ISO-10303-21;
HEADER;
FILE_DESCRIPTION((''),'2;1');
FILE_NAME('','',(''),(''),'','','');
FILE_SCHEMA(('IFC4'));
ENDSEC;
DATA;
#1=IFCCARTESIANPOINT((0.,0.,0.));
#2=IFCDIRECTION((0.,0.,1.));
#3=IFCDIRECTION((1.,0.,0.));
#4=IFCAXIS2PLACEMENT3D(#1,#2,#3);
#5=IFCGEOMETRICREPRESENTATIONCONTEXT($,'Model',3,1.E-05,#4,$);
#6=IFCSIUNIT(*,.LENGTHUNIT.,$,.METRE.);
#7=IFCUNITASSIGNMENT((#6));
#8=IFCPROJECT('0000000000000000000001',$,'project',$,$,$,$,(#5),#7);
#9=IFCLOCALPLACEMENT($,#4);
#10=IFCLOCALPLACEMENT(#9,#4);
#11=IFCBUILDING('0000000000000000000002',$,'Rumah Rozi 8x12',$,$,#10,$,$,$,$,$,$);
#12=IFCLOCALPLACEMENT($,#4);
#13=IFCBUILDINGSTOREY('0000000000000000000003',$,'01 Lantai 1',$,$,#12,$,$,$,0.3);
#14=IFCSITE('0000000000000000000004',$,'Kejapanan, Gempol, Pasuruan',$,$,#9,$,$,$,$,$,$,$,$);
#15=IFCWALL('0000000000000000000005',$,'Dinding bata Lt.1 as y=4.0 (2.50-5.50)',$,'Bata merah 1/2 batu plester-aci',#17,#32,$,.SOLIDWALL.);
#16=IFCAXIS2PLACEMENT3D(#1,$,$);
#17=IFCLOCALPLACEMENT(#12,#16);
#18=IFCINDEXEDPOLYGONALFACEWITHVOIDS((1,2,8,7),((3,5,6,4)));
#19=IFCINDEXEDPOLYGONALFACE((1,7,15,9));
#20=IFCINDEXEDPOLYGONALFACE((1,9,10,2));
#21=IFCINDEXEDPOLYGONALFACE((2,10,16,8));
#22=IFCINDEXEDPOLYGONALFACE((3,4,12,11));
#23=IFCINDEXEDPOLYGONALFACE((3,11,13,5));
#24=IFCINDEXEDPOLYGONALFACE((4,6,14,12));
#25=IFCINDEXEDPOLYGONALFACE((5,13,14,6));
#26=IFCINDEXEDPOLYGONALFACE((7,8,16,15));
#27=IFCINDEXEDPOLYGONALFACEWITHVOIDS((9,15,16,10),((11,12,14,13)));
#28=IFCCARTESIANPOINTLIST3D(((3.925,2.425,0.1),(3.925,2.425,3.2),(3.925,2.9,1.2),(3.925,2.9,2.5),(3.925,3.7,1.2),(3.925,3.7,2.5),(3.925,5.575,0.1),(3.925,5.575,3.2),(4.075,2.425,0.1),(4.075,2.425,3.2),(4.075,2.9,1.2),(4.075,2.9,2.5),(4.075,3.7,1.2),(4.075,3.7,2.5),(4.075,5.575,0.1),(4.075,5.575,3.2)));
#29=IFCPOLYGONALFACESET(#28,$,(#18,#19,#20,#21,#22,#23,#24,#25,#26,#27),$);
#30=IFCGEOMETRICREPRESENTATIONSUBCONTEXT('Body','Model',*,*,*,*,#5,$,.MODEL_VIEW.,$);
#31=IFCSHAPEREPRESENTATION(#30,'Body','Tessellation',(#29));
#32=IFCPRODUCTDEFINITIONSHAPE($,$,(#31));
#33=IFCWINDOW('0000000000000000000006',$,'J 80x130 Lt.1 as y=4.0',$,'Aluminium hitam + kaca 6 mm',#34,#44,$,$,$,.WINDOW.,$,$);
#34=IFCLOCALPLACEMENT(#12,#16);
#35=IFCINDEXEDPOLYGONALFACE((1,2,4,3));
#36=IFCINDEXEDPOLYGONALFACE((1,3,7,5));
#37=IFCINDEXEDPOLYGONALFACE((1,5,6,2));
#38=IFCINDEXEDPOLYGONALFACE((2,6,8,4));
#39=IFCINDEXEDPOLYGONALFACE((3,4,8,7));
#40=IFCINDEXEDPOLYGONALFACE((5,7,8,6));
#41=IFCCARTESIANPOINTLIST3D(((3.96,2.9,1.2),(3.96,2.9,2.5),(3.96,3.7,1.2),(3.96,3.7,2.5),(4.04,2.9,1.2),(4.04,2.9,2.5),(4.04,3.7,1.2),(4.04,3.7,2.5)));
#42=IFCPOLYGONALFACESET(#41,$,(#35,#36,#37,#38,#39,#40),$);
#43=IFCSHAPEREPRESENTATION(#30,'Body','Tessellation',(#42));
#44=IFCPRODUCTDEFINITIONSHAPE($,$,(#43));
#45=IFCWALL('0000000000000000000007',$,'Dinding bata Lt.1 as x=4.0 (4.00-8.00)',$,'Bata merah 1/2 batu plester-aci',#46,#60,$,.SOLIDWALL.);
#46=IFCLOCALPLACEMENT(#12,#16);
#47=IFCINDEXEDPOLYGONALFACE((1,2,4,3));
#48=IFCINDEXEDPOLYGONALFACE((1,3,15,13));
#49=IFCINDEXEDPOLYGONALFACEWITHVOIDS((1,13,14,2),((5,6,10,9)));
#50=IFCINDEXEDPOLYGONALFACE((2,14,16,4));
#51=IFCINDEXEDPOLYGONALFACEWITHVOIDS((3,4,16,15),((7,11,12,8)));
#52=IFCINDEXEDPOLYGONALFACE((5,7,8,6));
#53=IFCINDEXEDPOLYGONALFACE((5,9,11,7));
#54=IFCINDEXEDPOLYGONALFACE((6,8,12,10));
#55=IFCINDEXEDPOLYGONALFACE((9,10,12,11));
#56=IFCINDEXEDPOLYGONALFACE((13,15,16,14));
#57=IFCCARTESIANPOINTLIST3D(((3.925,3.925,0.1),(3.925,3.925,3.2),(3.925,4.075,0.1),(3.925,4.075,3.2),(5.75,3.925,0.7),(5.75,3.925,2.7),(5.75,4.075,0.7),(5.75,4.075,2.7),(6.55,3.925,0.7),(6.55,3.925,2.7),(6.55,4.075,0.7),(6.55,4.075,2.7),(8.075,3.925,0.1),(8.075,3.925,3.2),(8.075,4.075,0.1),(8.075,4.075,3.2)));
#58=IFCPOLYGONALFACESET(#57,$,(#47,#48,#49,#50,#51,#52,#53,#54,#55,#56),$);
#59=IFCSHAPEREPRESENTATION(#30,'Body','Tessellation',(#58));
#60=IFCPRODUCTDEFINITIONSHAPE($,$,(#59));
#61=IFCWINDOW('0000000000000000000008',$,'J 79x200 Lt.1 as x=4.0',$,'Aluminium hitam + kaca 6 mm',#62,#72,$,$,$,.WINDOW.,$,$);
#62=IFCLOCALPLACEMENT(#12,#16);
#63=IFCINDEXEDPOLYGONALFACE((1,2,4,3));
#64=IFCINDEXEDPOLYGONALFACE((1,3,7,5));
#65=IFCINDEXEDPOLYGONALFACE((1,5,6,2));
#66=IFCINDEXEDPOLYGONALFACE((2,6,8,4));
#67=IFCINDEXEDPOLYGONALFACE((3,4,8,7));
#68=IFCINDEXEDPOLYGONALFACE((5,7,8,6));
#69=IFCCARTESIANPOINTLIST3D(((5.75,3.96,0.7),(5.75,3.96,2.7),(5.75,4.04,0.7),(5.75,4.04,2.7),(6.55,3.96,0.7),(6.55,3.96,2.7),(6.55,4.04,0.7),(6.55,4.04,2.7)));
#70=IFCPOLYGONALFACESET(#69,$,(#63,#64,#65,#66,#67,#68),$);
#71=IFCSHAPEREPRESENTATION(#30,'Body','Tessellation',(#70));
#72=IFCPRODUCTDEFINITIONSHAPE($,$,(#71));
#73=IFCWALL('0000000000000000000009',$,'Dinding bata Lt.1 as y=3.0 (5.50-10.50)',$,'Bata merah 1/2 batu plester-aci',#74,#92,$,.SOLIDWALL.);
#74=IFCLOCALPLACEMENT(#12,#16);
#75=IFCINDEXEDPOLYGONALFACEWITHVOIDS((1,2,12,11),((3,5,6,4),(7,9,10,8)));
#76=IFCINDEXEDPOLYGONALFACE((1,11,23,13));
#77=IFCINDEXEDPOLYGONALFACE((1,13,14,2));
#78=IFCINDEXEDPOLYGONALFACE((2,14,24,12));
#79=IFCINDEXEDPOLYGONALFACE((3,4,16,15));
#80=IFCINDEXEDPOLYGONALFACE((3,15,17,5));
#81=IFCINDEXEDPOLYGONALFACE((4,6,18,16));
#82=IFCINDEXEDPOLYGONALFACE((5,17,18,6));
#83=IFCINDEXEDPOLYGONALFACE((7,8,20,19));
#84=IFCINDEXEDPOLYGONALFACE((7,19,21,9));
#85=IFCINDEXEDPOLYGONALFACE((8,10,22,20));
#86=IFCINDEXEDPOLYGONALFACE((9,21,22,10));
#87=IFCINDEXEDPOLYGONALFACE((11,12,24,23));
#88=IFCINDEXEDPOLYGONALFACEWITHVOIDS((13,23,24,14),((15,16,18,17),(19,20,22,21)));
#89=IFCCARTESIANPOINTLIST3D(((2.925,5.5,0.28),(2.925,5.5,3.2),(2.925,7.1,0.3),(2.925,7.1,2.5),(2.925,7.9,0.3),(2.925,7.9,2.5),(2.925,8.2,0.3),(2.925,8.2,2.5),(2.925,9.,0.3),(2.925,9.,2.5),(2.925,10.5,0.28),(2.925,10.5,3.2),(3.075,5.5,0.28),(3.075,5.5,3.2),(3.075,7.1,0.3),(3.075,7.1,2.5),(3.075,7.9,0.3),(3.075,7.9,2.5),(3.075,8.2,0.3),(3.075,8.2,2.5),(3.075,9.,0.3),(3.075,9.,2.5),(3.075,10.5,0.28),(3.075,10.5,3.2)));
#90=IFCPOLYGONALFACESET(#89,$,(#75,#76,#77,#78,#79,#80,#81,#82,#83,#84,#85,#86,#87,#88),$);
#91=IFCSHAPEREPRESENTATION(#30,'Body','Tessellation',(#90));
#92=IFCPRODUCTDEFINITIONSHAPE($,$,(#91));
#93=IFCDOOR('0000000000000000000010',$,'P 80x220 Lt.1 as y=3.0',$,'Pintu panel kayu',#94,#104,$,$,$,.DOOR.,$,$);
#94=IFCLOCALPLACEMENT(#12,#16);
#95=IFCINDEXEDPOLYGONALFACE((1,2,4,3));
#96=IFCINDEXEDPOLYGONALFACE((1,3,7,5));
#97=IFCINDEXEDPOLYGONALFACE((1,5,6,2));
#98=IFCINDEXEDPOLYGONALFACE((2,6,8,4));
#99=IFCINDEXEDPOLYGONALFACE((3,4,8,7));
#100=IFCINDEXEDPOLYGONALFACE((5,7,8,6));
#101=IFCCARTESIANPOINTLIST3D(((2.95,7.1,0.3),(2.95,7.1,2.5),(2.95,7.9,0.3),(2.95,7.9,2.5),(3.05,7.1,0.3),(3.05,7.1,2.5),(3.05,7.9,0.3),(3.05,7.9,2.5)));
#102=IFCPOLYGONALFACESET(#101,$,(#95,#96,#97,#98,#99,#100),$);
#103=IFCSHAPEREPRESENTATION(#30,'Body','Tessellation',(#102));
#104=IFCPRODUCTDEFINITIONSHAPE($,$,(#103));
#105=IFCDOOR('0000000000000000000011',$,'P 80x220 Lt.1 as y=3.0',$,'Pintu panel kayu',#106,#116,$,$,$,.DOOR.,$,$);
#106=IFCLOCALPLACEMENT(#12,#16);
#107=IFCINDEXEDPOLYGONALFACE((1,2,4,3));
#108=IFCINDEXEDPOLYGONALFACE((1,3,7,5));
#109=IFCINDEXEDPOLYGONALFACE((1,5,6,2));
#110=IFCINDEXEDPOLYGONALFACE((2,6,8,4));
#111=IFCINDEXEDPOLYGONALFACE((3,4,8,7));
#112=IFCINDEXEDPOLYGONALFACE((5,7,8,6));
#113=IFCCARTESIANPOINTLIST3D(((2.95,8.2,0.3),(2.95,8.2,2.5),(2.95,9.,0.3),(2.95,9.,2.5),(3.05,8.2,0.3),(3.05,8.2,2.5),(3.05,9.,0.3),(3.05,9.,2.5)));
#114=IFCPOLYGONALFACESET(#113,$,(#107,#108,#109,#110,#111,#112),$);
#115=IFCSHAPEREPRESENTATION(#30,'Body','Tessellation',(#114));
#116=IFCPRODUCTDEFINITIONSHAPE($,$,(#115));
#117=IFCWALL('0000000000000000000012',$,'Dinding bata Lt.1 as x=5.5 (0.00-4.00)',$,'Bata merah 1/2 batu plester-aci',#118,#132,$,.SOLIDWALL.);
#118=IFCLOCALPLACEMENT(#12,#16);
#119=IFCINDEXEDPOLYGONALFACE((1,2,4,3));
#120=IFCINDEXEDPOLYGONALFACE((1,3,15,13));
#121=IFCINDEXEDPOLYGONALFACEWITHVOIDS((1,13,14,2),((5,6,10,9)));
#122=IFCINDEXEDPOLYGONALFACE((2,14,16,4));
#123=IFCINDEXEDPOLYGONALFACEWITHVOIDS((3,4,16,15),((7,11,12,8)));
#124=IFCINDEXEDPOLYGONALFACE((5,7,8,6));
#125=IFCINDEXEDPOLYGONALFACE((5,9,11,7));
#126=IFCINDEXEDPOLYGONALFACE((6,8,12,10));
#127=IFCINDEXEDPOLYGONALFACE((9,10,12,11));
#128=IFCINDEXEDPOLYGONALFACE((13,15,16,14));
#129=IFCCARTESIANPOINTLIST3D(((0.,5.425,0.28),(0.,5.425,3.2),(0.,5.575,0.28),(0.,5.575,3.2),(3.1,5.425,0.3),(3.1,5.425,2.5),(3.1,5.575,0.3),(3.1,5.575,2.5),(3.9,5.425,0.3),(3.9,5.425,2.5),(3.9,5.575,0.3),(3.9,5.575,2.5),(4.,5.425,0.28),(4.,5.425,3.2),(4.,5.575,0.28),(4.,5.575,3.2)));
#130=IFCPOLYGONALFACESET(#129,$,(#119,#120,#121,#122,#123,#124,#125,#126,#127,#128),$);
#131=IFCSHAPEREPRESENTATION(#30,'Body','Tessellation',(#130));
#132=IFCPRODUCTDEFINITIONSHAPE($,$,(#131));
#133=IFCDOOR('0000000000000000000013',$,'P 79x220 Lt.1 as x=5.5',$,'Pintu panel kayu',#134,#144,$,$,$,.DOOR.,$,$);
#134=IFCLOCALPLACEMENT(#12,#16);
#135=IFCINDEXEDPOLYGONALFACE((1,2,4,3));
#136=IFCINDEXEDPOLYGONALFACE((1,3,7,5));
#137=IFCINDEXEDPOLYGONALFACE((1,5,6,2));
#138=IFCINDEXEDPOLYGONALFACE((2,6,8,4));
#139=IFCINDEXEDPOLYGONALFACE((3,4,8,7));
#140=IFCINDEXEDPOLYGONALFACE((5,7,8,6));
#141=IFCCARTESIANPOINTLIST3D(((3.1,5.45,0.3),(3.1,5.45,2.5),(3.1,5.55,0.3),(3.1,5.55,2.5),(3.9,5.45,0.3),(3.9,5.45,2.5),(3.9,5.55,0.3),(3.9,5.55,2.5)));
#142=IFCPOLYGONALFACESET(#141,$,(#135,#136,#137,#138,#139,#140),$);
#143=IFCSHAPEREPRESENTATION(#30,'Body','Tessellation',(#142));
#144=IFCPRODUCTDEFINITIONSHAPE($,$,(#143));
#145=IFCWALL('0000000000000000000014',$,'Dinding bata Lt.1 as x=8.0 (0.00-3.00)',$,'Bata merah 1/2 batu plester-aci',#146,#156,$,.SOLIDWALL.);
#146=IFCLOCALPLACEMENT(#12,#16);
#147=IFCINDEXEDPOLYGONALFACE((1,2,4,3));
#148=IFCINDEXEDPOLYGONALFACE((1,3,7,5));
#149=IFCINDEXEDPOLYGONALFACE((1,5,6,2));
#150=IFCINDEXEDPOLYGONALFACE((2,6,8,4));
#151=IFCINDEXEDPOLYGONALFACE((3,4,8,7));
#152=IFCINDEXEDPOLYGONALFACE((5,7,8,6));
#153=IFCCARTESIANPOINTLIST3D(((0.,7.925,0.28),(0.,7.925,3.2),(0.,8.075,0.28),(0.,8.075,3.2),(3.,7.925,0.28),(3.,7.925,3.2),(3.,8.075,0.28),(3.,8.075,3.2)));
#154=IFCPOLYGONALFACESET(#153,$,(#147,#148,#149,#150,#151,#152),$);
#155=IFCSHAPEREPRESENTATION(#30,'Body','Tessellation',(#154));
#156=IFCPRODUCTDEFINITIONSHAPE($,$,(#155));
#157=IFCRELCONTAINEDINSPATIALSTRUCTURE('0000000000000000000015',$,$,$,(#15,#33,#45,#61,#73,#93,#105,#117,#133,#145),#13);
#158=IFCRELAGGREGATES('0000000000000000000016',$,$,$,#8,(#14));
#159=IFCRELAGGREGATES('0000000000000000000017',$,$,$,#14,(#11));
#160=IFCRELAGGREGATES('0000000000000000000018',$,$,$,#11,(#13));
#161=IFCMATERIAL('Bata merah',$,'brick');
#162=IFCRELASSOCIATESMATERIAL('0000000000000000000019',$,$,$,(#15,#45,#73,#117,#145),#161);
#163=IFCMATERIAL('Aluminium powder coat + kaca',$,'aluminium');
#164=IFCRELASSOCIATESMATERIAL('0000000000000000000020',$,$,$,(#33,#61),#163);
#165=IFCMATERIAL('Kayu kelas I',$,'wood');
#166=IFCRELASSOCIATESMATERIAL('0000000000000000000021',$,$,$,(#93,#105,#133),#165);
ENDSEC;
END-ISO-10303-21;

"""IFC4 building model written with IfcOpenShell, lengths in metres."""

from ifc_helpers import new_model, si_unit, frame, origin_with_axes, place, context, subcontext, project, spatial, line, indexed_curve, outline, extrude, material, element, fill, save


model = new_model("IFC4")

# Units and contexts
model_context = context("Model", 3, precision=1e-05, world=origin_with_axes())
body_context = subcontext(model_context, "Body", "Model", "MODEL_VIEW")
ifc_project = project(units=[si_unit("LENGTHUNIT", "METRE")], contexts=[model_context])

# Site, building, storey
site_placement = place(None, origin_with_axes())
site = spatial("IfcSite", under=ifc_project, at=site_placement, Name="Kejapanan, Gempol, Pasuruan")
building_placement = place(site_placement, origin_with_axes())
building = spatial("IfcBuilding", under=site, at=building_placement, Name="Rumah Rozi 8x12")
storey_placement = place(None, origin_with_axes())
storey = spatial("IfcBuildingStorey", under=building, at=storey_placement, Name="01 Lantai 1", Elevation=0.3)

# Shared definitions
ifc_material_1 = material(Name="Bata merah", Category="brick")
ifc_material_2 = material(Name="Aluminium powder coat + kaca", Category="aluminium")

# Shared definitions
ifc_material_3 = material(Name="Kayu kelas I", Category="wood")

# Walls, openings, windows
wall_1_placement = place(storey_placement, origin_with_axes())
wall_1 = element("IfcWall", 1, at=wall_1_placement, inside=storey, material=ifc_material_1, Name="Dinding bata Lt.1 as y=4.0 (2.50-5.50)", ObjectType="Bata merah 1/2 batu plester-aci", PredefinedType="SOLIDWALL", context=body_context, shape_type="SweptSolid", body=[
    extrude(outline(indexed_curve([(3.925, 2.425), (4.075, 2.425), (4.075, 5.575), (3.925, 5.575)], segments=[line(1, 2, 3, 4, 1)])), frame((0.0, 0.0, 0.1), z_axis=(0.0, 0.0, 1.0), x_axis=(1.0, 0.0, 0.0)), (0.0, 0.0, 1.0), 3.1),
])
opening_1_placement = place(wall_1_placement, origin_with_axes())
opening_1 = element("IfcOpeningElement", 2, at=opening_1_placement, cuts=wall_1, context=body_context, shape_type="SweptSolid", body=[
    extrude(outline(indexed_curve([(3.915, 2.9), (4.085, 2.9), (4.085, 3.7), (3.915, 3.7)], segments=[line(1, 2, 3, 4, 1)])), frame((0.0, 0.0, 1.2), z_axis=(0.0, 0.0, 1.0), x_axis=(1.0, 0.0, 0.0)), (0.0, 0.0, 1.0), 1.3),
])
window_1_placement = place(storey_placement, origin_with_axes())
window_1 = element("IfcWindow", 3, at=window_1_placement, inside=storey, material=ifc_material_2, Name="J 80x130 Lt.1 as y=4.0", ObjectType="Aluminium hitam + kaca 6 mm", PredefinedType="WINDOW", context=body_context, shape_type="SweptSolid", body=[
    extrude(outline(indexed_curve([(3.96, 2.9), (4.04, 2.9), (4.04, 3.7), (3.96, 3.7)], segments=[line(1, 2, 3, 4, 1)])), frame((0.0, 0.0, 1.2), z_axis=(0.0, 0.0, 1.0), x_axis=(1.0, 0.0, 0.0)), (0.0, 0.0, 1.0), 1.3),
])
fill(opening_1, window_1)
wall_2_placement = place(storey_placement, origin_with_axes())
wall_2 = element("IfcWall", 4, at=wall_2_placement, inside=storey, material=ifc_material_1, Name="Dinding bata Lt.1 as x=4.0 (4.00-8.00)", ObjectType="Bata merah 1/2 batu plester-aci", PredefinedType="SOLIDWALL", context=body_context, shape_type="SweptSolid", body=[
    extrude(outline(indexed_curve([(3.925, 3.925), (8.075, 3.925), (8.075, 4.075), (3.925, 4.075)], segments=[line(1, 2, 3, 4, 1)])), frame((0.0, 0.0, 0.1), z_axis=(0.0, 0.0, 1.0), x_axis=(1.0, 0.0, 0.0)), (0.0, 0.0, 1.0), 3.1),
])
opening_2_placement = place(wall_2_placement, origin_with_axes())
opening_2 = element("IfcOpeningElement", 5, at=opening_2_placement, cuts=wall_2, context=body_context, shape_type="SweptSolid", body=[
    extrude(outline(indexed_curve([(5.75, 3.915), (6.55, 3.915), (6.55, 4.085), (5.75, 4.085)], segments=[line(1, 2, 3, 4, 1)])), frame((0.0, 0.0, 0.7), z_axis=(0.0, 0.0, 1.0), x_axis=(1.0, 0.0, 0.0)), (0.0, 0.0, 1.0), 2.0),
])
window_2_placement = place(storey_placement, origin_with_axes())
window_2 = element("IfcWindow", 6, at=window_2_placement, inside=storey, material=ifc_material_2, Name="J 79x200 Lt.1 as x=4.0", ObjectType="Aluminium hitam + kaca 6 mm", PredefinedType="WINDOW", context=body_context, shape_type="SweptSolid", body=[
    extrude(outline(indexed_curve([(5.75, 3.96), (6.55, 3.96), (6.55, 4.04), (5.75, 4.04)], segments=[line(1, 2, 3, 4, 1)])), frame((0.0, 0.0, 0.7), z_axis=(0.0, 0.0, 1.0), x_axis=(1.0, 0.0, 0.0)), (0.0, 0.0, 1.0), 2.0),
])
fill(opening_2, window_2)

# Wall, openings, doors
wall_3_placement = place(storey_placement, origin_with_axes())
wall_3 = element("IfcWall", 7, at=wall_3_placement, inside=storey, material=ifc_material_1, Name="Dinding bata Lt.1 as y=3.0 (5.50-10.50)", ObjectType="Bata merah 1/2 batu plester-aci", PredefinedType="SOLIDWALL", context=body_context, shape_type="SweptSolid", body=[
    extrude(outline(indexed_curve([(2.925, 5.5), (3.075, 5.5), (3.075, 10.5), (2.925, 10.5)], segments=[line(1, 2, 3, 4, 1)])), frame((0.0, 0.0, 0.28), z_axis=(0.0, 0.0, 1.0), x_axis=(1.0, 0.0, 0.0)), (0.0, 0.0, 1.0), 2.92),
])
opening_3_placement = place(wall_3_placement, origin_with_axes())
opening_3 = element("IfcOpeningElement", 8, at=opening_3_placement, cuts=wall_3, context=body_context, shape_type="SweptSolid", body=[
    extrude(outline(indexed_curve([(2.915, 7.1), (3.085, 7.1), (3.085, 7.9), (2.915, 7.9)], segments=[line(1, 2, 3, 4, 1)])), frame((0.0, 0.0, 0.3), z_axis=(0.0, 0.0, 1.0), x_axis=(1.0, 0.0, 0.0)), (0.0, 0.0, 1.0), 2.2),
])
opening_4_placement = place(wall_3_placement, origin_with_axes())
opening_4 = element("IfcOpeningElement", 9, at=opening_4_placement, cuts=wall_3, context=body_context, shape_type="SweptSolid", body=[
    extrude(outline(indexed_curve([(2.915, 8.2), (3.085, 8.2), (3.085, 9.0), (2.915, 9.0)], segments=[line(1, 2, 3, 4, 1)])), frame((0.0, 0.0, 0.3), z_axis=(0.0, 0.0, 1.0), x_axis=(1.0, 0.0, 0.0)), (0.0, 0.0, 1.0), 2.2),
])
door_1_placement = place(storey_placement, origin_with_axes())
door_1 = element("IfcDoor", 10, at=door_1_placement, inside=storey, material=ifc_material_3, Name="P 80x220 Lt.1 as y=3.0", ObjectType="Pintu panel kayu", PredefinedType="DOOR", context=body_context, shape_type="SweptSolid", body=[
    extrude(outline(indexed_curve([(2.95, 7.1), (3.05, 7.1), (3.05, 7.9), (2.95, 7.9)], segments=[line(1, 2, 3, 4, 1)])), frame((0.0, 0.0, 0.3), z_axis=(0.0, 0.0, 1.0), x_axis=(1.0, 0.0, 0.0)), (0.0, 0.0, 1.0), 2.2),
])
fill(opening_3, door_1)
door_2_placement = place(storey_placement, origin_with_axes())
door_2 = element("IfcDoor", 11, at=door_2_placement, inside=storey, material=ifc_material_3, Name="P 80x220 Lt.1 as y=3.0", ObjectType="Pintu panel kayu", PredefinedType="DOOR", context=body_context, shape_type="SweptSolid", body=[
    extrude(outline(indexed_curve([(2.95, 8.2), (3.05, 8.2), (3.05, 9.0), (2.95, 9.0)], segments=[line(1, 2, 3, 4, 1)])), frame((0.0, 0.0, 0.3), z_axis=(0.0, 0.0, 1.0), x_axis=(1.0, 0.0, 0.0)), (0.0, 0.0, 1.0), 2.2),
])
fill(opening_4, door_2)

# Wall, opening, door
wall_4_placement = place(storey_placement, origin_with_axes())
wall_4 = element("IfcWall", 12, at=wall_4_placement, inside=storey, material=ifc_material_1, Name="Dinding bata Lt.1 as x=5.5 (0.00-4.00)", ObjectType="Bata merah 1/2 batu plester-aci", PredefinedType="SOLIDWALL", context=body_context, shape_type="SweptSolid", body=[
    extrude(outline(indexed_curve([(0.0, 5.425), (4.0, 5.425), (4.0, 5.575), (0.0, 5.575)], segments=[line(1, 2, 3, 4, 1)])), frame((0.0, 0.0, 0.28), z_axis=(0.0, 0.0, 1.0), x_axis=(1.0, 0.0, 0.0)), (0.0, 0.0, 1.0), 2.92),
])
opening_5_placement = place(wall_4_placement, origin_with_axes())
opening_5 = element("IfcOpeningElement", 13, at=opening_5_placement, cuts=wall_4, context=body_context, shape_type="SweptSolid", body=[
    extrude(outline(indexed_curve([(3.1, 5.415), (3.9, 5.415), (3.9, 5.585), (3.1, 5.585)], segments=[line(1, 2, 3, 4, 1)])), frame((0.0, 0.0, 0.3), z_axis=(0.0, 0.0, 1.0), x_axis=(1.0, 0.0, 0.0)), (0.0, 0.0, 1.0), 2.2),
])
door_3_placement = place(storey_placement, origin_with_axes())
door_3 = element("IfcDoor", 14, at=door_3_placement, inside=storey, material=ifc_material_3, Name="P 79x220 Lt.1 as x=5.5", ObjectType="Pintu panel kayu", PredefinedType="DOOR", context=body_context, shape_type="SweptSolid", body=[
    extrude(outline(indexed_curve([(3.1, 5.45), (3.9, 5.45), (3.9, 5.55), (3.1, 5.55)], segments=[line(1, 2, 3, 4, 1)])), frame((0.0, 0.0, 0.3), z_axis=(0.0, 0.0, 1.0), x_axis=(1.0, 0.0, 0.0)), (0.0, 0.0, 1.0), 2.2),
])
fill(opening_5, door_3)

# Wall
wall_5_placement = place(storey_placement, origin_with_axes())
element("IfcWall", 15, at=wall_5_placement, inside=storey, material=ifc_material_1, Name="Dinding bata Lt.1 as x=8.0 (0.00-3.00)", ObjectType="Bata merah 1/2 batu plester-aci", PredefinedType="SOLIDWALL", context=body_context, shape_type="SweptSolid", body=[
    extrude(outline(indexed_curve([(0.0, 7.925), (3.0, 7.925), (3.0, 8.075), (0.0, 8.075)], segments=[line(1, 2, 3, 4, 1)])), frame((0.0, 0.0, 0.28), z_axis=(0.0, 0.0, 1.0), x_axis=(1.0, 0.0, 0.0)), (0.0, 0.0, 1.0), 2.92),
])

save(model, "model.ifc")
